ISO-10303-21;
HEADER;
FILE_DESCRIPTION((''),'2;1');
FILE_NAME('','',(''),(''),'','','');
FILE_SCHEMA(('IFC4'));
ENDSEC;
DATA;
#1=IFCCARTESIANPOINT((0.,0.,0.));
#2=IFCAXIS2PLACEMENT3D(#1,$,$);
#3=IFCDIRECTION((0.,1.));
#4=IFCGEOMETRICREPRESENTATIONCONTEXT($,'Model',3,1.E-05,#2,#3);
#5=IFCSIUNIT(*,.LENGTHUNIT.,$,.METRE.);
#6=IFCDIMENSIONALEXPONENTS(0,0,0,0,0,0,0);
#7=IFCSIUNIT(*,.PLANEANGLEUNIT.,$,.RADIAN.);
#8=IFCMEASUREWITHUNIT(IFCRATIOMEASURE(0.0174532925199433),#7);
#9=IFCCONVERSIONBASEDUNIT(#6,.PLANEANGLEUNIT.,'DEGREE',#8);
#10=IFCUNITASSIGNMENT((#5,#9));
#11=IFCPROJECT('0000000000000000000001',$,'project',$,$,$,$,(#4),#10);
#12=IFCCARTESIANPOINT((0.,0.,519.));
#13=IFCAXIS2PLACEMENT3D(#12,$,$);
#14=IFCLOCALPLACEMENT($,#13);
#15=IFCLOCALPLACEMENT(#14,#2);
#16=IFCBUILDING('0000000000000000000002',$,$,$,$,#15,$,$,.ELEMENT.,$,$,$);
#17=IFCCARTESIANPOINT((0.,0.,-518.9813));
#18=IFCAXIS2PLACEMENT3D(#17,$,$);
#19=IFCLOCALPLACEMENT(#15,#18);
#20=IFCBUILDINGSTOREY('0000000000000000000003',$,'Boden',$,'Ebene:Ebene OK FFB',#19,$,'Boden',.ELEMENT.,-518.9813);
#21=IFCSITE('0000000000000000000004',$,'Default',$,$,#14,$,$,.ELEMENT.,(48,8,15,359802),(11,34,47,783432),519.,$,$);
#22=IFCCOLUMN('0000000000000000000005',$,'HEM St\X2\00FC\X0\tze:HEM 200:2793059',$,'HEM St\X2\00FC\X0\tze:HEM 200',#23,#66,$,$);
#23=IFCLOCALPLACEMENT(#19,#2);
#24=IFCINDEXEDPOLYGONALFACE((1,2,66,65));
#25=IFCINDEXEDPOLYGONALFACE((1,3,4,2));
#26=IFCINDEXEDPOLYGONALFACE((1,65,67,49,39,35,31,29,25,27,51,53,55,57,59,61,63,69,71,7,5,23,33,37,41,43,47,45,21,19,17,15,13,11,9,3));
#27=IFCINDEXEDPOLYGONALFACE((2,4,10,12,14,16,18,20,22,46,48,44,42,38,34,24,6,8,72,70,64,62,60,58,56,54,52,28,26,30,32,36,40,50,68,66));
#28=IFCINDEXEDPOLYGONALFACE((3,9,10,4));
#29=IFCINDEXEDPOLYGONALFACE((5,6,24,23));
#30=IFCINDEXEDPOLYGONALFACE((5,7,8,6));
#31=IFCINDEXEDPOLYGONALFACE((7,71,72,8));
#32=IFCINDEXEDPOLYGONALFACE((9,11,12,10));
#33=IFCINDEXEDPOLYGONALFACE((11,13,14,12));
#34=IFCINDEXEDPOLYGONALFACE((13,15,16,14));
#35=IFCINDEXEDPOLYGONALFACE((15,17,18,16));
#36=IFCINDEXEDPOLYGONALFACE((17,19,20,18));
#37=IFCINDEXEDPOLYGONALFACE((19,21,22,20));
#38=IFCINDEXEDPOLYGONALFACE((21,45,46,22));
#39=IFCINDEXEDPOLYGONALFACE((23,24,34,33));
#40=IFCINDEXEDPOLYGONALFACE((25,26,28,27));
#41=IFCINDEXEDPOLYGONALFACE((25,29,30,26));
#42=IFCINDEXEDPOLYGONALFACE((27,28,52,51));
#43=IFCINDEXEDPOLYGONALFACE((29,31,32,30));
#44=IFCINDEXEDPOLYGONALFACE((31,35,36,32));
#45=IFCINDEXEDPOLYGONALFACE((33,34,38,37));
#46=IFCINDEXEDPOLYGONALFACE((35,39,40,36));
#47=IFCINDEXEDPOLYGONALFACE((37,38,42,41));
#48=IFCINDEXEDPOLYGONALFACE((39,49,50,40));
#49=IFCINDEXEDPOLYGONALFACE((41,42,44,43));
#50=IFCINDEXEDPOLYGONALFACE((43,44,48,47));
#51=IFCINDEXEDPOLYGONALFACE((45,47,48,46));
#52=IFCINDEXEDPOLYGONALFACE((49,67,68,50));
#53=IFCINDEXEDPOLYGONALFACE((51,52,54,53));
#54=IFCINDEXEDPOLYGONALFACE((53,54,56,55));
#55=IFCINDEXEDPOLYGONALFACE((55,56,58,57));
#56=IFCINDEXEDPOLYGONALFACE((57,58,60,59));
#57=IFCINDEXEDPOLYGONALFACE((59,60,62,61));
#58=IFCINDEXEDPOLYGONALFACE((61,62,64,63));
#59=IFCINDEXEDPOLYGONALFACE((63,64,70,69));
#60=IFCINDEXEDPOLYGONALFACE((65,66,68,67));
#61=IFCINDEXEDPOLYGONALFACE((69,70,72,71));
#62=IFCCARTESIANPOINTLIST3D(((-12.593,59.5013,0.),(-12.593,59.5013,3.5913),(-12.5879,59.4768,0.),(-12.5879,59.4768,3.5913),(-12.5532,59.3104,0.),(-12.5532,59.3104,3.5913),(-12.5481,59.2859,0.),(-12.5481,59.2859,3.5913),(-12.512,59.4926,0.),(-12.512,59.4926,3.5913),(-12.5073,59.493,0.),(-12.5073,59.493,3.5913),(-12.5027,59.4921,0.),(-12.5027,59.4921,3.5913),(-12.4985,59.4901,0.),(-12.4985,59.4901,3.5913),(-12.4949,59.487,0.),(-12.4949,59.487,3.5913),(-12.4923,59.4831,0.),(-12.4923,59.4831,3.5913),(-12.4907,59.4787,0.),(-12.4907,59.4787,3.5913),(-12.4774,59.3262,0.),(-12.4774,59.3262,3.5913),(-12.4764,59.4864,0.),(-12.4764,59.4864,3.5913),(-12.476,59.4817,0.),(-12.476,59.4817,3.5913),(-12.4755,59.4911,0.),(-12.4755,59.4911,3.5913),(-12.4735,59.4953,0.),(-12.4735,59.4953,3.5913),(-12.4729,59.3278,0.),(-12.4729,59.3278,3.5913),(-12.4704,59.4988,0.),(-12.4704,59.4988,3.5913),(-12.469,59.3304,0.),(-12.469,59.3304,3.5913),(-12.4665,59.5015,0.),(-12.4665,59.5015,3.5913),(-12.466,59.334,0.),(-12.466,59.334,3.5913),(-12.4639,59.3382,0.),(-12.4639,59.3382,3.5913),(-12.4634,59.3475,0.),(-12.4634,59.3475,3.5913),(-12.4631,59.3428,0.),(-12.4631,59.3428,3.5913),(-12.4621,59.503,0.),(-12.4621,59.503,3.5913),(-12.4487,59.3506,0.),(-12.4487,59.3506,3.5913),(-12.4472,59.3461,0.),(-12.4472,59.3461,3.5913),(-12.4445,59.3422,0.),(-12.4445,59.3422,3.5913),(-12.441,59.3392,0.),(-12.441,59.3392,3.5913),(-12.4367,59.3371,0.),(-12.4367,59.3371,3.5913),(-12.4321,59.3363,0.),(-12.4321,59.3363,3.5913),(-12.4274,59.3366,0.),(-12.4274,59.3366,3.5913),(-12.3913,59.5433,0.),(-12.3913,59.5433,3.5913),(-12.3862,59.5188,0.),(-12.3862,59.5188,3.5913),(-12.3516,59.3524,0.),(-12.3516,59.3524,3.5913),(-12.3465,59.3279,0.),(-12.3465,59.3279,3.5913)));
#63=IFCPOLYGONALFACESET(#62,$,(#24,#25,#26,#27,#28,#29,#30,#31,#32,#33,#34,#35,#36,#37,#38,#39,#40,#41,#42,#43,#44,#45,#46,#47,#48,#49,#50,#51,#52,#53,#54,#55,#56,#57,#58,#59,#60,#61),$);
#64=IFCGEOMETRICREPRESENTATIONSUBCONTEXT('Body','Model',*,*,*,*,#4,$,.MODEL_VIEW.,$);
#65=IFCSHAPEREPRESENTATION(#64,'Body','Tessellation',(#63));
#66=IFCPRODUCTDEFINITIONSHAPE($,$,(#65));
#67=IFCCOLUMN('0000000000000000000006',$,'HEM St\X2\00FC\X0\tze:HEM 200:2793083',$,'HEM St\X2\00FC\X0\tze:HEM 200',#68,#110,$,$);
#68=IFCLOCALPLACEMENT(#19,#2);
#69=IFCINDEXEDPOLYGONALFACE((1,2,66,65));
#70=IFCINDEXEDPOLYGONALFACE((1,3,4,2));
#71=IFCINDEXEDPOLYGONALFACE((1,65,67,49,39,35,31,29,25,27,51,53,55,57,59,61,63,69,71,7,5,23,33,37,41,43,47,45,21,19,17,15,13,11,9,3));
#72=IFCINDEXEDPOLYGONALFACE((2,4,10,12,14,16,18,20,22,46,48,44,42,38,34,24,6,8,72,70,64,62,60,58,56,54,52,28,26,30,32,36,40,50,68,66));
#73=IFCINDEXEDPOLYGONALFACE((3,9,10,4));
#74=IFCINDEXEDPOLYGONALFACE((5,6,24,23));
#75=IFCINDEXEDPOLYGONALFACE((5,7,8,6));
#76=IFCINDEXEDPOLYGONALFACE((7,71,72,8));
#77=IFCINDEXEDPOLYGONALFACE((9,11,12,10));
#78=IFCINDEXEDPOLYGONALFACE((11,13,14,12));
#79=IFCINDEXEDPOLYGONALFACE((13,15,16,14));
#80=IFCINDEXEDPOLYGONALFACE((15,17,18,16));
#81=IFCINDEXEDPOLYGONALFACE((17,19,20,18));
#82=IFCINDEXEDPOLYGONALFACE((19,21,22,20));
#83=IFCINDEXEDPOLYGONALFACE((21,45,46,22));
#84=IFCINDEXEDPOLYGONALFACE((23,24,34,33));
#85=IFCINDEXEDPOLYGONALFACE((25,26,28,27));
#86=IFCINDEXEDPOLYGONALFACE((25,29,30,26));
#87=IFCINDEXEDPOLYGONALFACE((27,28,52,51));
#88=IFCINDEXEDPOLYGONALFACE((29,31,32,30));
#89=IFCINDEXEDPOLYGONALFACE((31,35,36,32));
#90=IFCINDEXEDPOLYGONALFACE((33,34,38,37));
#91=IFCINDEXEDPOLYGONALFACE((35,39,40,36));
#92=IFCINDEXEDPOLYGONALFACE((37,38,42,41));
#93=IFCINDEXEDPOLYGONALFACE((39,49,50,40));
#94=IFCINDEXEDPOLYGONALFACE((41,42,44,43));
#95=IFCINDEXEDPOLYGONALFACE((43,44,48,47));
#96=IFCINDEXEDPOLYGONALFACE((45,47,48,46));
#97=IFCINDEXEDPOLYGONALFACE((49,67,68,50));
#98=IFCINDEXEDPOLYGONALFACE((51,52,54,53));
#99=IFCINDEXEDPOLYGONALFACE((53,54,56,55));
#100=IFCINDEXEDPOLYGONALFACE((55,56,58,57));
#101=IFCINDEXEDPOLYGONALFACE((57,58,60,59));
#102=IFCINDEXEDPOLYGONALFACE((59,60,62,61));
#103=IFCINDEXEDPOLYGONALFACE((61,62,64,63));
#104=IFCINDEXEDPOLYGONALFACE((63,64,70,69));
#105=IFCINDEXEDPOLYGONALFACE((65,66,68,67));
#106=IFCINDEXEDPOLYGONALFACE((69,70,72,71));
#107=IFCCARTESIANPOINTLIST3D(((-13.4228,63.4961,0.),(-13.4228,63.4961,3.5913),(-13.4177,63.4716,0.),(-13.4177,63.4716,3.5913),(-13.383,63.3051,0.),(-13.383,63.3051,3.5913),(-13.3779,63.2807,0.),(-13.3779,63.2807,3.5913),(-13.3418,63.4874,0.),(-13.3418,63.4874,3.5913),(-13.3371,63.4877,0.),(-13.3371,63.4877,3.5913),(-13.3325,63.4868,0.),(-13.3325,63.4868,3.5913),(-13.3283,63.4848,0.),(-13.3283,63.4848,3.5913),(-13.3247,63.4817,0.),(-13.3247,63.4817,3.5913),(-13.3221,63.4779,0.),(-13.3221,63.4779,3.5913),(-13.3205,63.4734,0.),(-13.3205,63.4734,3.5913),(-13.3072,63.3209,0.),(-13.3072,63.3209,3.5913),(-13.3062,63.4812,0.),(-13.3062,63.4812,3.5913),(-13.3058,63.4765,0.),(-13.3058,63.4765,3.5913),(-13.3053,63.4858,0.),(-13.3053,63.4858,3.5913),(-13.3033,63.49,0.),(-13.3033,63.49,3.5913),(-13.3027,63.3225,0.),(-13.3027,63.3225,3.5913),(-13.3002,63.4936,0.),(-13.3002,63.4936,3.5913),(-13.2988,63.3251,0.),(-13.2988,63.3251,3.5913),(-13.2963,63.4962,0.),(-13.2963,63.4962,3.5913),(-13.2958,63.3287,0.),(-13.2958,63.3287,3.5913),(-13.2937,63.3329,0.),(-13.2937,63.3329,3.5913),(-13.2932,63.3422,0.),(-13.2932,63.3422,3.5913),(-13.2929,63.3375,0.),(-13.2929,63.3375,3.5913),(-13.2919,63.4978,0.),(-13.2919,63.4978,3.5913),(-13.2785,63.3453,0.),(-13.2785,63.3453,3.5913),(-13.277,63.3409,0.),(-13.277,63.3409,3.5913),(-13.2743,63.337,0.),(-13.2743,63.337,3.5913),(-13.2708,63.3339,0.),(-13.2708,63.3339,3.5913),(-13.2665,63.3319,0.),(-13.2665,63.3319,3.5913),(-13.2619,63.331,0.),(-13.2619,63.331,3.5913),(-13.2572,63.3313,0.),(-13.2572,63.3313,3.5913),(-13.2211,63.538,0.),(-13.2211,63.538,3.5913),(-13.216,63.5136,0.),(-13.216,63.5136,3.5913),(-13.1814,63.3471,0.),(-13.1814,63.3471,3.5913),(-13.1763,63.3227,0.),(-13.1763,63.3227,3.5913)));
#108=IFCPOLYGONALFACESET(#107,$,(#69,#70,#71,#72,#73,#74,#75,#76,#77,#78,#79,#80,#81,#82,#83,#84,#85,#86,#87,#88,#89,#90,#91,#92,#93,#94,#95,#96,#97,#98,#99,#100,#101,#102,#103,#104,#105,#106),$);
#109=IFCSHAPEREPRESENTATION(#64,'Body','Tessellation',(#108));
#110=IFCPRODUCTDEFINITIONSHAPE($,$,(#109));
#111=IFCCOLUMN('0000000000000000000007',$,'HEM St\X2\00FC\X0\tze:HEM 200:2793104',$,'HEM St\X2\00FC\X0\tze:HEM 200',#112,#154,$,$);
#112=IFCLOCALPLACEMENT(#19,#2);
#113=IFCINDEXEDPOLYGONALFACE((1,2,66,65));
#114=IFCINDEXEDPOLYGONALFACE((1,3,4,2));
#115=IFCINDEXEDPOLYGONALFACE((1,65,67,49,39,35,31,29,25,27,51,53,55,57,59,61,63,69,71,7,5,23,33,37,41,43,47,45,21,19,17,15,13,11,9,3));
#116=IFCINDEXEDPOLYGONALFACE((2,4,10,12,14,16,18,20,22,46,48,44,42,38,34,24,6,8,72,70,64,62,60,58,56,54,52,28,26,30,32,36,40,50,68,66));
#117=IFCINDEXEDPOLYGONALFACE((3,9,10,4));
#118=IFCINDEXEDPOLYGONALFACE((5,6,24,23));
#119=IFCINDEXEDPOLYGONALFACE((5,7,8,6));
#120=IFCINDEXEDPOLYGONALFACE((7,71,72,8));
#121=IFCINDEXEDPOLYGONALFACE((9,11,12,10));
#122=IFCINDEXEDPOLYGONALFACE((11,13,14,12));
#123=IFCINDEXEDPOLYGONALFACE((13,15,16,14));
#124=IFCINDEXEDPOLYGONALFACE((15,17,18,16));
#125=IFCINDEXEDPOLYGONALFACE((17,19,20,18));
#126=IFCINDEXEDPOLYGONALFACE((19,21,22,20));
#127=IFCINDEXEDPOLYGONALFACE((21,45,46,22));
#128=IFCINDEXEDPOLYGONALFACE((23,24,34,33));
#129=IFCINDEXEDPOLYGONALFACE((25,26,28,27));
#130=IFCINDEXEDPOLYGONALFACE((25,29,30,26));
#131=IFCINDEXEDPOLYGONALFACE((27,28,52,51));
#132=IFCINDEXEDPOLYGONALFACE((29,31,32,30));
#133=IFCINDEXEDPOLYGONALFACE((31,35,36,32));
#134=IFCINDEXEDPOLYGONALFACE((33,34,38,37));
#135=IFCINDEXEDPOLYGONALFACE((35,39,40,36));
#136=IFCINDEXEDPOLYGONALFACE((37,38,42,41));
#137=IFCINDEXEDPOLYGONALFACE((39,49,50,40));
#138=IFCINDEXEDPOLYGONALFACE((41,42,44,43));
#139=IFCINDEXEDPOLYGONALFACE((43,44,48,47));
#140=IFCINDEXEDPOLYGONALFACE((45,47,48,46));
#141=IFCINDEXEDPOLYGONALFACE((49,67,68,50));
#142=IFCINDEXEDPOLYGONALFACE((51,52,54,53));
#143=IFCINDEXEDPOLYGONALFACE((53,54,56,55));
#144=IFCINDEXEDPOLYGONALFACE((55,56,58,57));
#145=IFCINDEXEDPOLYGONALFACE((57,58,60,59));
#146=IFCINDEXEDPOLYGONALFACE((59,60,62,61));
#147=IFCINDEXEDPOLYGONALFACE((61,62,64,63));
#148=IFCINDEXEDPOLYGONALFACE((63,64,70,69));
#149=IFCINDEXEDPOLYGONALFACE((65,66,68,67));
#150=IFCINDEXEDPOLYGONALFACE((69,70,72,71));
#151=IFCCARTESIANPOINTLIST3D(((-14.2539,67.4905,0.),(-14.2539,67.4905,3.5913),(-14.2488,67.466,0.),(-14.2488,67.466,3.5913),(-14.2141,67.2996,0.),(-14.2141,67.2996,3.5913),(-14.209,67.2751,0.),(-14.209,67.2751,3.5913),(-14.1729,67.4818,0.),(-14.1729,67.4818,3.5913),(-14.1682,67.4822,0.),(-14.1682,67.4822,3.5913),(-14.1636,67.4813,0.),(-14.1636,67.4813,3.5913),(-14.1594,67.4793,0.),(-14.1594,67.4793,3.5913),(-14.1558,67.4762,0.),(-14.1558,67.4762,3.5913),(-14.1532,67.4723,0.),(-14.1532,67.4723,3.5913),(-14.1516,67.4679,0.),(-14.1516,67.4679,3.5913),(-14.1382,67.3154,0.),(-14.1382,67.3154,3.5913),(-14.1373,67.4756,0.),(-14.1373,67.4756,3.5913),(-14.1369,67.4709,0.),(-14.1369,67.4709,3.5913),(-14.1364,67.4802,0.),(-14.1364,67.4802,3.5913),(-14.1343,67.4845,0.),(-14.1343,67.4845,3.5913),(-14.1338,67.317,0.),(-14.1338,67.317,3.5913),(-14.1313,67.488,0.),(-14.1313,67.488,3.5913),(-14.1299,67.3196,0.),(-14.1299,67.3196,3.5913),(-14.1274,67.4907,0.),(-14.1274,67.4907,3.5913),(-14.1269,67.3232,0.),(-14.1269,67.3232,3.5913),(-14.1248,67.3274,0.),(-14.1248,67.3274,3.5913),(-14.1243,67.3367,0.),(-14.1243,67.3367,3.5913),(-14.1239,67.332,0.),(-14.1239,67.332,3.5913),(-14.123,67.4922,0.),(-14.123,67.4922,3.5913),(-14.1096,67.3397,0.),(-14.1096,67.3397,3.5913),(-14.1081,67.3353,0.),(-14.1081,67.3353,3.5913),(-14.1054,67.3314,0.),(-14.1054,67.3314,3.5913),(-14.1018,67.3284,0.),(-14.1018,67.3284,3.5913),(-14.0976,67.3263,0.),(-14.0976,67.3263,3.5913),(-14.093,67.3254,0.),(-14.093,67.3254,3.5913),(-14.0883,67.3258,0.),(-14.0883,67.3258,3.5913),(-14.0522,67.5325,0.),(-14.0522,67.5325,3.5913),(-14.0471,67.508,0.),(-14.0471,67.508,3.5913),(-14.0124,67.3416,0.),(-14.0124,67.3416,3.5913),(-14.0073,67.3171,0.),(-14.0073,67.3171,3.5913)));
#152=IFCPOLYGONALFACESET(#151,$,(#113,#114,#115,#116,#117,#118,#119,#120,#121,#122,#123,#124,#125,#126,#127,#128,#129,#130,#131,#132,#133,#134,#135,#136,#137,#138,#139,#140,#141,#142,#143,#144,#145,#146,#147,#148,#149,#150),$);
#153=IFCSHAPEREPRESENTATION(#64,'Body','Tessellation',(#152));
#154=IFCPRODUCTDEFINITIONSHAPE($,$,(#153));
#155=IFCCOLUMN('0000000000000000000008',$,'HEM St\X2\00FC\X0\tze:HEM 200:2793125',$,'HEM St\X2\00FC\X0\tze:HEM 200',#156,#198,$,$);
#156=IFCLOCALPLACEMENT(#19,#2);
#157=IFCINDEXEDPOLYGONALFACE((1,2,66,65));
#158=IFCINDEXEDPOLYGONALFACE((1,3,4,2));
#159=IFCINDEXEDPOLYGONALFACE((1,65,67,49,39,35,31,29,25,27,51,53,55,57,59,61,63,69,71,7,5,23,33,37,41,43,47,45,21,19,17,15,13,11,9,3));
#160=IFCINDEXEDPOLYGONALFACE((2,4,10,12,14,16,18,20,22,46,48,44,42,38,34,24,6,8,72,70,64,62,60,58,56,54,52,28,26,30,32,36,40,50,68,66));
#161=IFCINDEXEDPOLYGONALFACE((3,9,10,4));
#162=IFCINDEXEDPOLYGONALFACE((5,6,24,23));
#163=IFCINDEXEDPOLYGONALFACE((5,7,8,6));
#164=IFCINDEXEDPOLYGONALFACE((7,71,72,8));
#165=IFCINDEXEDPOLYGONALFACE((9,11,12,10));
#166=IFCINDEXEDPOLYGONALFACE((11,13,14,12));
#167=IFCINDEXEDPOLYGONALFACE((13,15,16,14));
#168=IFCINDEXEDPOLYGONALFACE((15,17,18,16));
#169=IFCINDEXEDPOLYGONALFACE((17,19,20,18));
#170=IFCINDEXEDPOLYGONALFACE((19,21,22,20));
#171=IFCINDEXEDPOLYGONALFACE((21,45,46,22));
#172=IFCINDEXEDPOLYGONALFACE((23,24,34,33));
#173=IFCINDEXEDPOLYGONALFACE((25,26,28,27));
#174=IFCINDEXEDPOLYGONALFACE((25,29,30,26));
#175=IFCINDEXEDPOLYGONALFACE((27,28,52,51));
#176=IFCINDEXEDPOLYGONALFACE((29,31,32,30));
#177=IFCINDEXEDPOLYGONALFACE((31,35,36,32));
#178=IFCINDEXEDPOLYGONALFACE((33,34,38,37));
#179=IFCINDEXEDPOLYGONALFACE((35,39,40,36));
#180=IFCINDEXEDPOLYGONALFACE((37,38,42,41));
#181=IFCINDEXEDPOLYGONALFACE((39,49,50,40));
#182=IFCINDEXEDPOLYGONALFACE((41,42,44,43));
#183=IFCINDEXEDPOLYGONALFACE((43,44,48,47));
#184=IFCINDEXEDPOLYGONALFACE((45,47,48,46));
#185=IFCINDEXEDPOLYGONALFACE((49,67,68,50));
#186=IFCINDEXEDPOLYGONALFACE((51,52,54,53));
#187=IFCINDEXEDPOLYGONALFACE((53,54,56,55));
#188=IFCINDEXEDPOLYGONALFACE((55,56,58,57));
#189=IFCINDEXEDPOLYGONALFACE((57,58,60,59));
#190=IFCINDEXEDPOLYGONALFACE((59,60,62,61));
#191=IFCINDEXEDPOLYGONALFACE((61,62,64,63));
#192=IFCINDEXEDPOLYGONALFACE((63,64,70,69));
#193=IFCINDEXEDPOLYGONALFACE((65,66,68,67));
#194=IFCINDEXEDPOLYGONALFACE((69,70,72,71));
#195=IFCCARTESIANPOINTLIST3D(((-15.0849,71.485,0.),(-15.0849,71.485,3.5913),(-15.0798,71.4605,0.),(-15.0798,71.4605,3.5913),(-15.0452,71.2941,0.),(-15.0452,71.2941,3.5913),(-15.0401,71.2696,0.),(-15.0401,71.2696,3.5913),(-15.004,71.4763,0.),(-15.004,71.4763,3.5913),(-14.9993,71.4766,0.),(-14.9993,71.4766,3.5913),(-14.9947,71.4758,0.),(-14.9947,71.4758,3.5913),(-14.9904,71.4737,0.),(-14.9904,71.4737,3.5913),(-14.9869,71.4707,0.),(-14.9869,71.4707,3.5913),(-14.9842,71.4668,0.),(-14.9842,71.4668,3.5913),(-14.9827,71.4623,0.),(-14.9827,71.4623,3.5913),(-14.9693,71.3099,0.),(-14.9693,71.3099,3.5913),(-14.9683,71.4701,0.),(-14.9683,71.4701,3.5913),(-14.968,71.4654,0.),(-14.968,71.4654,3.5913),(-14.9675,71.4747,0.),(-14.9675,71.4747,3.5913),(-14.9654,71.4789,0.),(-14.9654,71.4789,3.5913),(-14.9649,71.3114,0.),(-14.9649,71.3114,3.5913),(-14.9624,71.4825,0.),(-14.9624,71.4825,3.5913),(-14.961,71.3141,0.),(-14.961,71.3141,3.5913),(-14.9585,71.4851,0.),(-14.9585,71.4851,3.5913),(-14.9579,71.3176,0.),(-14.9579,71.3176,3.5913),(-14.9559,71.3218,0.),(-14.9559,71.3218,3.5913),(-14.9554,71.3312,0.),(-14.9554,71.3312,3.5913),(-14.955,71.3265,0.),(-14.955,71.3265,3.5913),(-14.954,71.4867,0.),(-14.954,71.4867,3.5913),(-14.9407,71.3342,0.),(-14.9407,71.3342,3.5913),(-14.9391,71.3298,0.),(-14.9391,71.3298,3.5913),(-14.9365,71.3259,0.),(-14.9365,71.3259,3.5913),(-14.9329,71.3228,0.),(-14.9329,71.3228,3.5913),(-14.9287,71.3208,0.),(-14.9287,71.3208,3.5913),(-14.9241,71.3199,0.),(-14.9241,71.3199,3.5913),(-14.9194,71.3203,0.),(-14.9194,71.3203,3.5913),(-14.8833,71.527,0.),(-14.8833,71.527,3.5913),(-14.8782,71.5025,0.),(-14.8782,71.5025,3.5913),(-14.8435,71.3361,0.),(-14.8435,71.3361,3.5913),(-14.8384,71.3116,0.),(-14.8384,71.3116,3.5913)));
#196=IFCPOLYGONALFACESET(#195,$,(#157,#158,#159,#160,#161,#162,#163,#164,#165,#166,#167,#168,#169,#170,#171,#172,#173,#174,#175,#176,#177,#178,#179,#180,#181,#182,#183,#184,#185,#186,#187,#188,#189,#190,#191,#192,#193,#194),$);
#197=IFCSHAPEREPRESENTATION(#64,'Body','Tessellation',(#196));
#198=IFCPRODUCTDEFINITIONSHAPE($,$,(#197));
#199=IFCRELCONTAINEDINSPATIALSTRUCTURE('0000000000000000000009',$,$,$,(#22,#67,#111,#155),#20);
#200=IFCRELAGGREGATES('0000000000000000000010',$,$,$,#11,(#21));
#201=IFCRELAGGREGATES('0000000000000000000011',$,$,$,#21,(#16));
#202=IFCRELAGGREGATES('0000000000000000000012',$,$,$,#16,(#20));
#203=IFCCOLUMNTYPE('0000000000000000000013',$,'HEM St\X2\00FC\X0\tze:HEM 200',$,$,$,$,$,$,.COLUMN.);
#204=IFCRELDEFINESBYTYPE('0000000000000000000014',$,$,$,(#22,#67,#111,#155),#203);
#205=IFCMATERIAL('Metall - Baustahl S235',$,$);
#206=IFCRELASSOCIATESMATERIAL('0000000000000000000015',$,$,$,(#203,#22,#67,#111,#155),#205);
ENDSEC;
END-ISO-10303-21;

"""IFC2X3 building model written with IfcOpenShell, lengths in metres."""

from ifc_helpers import new_model, entity, si_unit, converted_unit, direction, frame, frame_2d, origin, place, context, subcontext, project, spatial, polyline, circle_curve, parameter, trimmed, segment, composite_curve, outline, extrude, source, transform, mapped, material, type_object, type_shapes, element, save


model = new_model("IFC2X3")

# Units and contexts
model_context = context("Model", 3, precision=1e-05, world=origin(), true_north=direction((0.0, 1.0)))
body_context = subcontext(model_context, "Body", "Model", "MODEL_VIEW")
ifc_project = project(units=[si_unit("LENGTHUNIT", "METRE"), converted_unit("PLANEANGLEUNIT", "DEGREE", entity("IfcRatioMeasure", 0.0174532925199433), si_unit("PLANEANGLEUNIT", "RADIAN"), dimensions=[0, 0, 0, 0, 0, 0, 0])], contexts=[model_context])

# Site, building, storey
site_placement = place(None, frame((0.0, 0.0, 519.0)))
site = spatial("IfcSite", under=ifc_project, at=site_placement, Name="Default", CompositionType="ELEMENT", RefLatitude=(48, 8, 15, 359802), RefLongitude=(11, 34, 47, 783432), RefElevation=519.0)
building_placement = place(site_placement, origin())
building = spatial("IfcBuilding", under=site, at=building_placement, CompositionType="ELEMENT")
storey_placement = place(building_placement, frame((0.0, 0.0, -518.9813)))
storey = spatial("IfcBuildingStorey", under=building, at=storey_placement, Name="Boden", ObjectType="Ebene:Ebene OK FFB", LongName="Boden", CompositionType="ELEMENT", Elevation=-518.9813)

# Columns
ifc_material = material(Name="Metall - Baustahl S235")
column_type = type_object("IfcColumnType", Name="HEM Stütze:HEM 200", PredefinedType="COLUMN", material=ifc_material)
shared_shape = source(origin(), body_context, "Body", "SweptSolid", [
    extrude(outline(composite_curve([segment(polyline([(0.085, -0.103), (0.11, -0.103)]), True, "CONTINUOUS"), segment(polyline([(0.11, -0.103), (0.11, 0.103)]), True, "CONTINUOUS"), segment(polyline([(0.11, 0.103), (0.085, 0.103)]), True, "CONTINUOUS"), segment(polyline([(0.085, 0.103), (0.085, 0.0255)]), True, "CONTINUOUS"), segment(trimmed(circle_curve(frame_2d((0.067, 0.0255), x_axis=(1.0, 0.0)), 0.018), [parameter(270.0)], [parameter(0.0)], True, "PARAMETER"), False, "CONTINUOUS"), segment(polyline([(0.067, 0.0075), (-0.067, 0.0075)]), True, "CONTINUOUS"), segment(trimmed(circle_curve(frame_2d((-0.067, 0.0255), x_axis=(0.0, -1.0)), 0.018), [parameter(270.0)], [parameter(0.0)], True, "PARAMETER"), False, "CONTINUOUS"), segment(polyline([(-0.085, 0.0255), (-0.085, 0.103)]), True, "CONTINUOUS"), segment(polyline([(-0.085, 0.103), (-0.11, 0.103)]), True, "CONTINUOUS"), segment(polyline([(-0.11, 0.103), (-0.11, -0.103)]), True, "CONTINUOUS"), segment(polyline([(-0.11, -0.103), (-0.085, -0.103)]), True, "CONTINUOUS"), segment(polyline([(-0.085, -0.103), (-0.085, -0.0255)]), True, "CONTINUOUS"), segment(trimmed(circle_curve(frame_2d((-0.067, -0.0255), x_axis=(-1.0, 0.0)), 0.018), [parameter(270.0)], [parameter(0.0)], True, "PARAMETER"), False, "CONTINUOUS"), segment(polyline([(-0.067, -0.0075), (0.067, -0.0075)]), True, "CONTINUOUS"), segment(trimmed(circle_curve(frame_2d((0.067, -0.0255), x_axis=(0.0, 1.0)), 0.018), [parameter(270.0)], [parameter(0.0)], True, "PARAMETER"), False, "CONTINUOUS"), segment(polyline([(0.085, -0.0255), (0.085, -0.103)]), True, "CONTINUOUS")], self_intersect=False)), frame((0.0, 0.0, -518.9813), z_axis=(0.0, 0.0, 1.0), x_axis=(0.0, -1.0, 0.0)), (0.0, 0.0, 1.0), 3.5913),
])
type_shapes(column_type, [shared_shape])
for number, where, z_axis, x_axis, name in (
    (1, (-12.4697, 59.4146, 518.9813), (0.0, 0.0, 1.0), (0.979008, 0.20382, 0.0), "HEM Stütze:HEM 200:2793059"),
    (2, (-13.2995, 63.4094, 518.9813), (0.0, 0.0, 1.0), (0.979008, 0.20382, 0.0), "HEM Stütze:HEM 200:2793083"),
    (3, (-14.1306, 67.4038, 518.9813), (0.0, 0.0, 1.0), (0.979008, 0.20382, 0.0), "HEM Stütze:HEM 200:2793104"),
    (4, (-14.9617, 71.3983, 518.9813), (0.0, 0.0, 1.0), (0.979008, 0.20382, 0.0), "HEM Stütze:HEM 200:2793125"),
):
    element("IfcColumn", number, at=place(storey_placement, frame(where, z_axis=z_axis, x_axis=x_axis)), inside=storey, type_object=column_type, material=ifc_material, Name=name, ObjectType="HEM Stütze:HEM 200", context=body_context, shape_type="MappedRepresentation", body=[
        mapped(shared_shape, transform((0.0, 0.0, 0.0), scale=1.0)),
    ])

save(model, "model.ifc")
